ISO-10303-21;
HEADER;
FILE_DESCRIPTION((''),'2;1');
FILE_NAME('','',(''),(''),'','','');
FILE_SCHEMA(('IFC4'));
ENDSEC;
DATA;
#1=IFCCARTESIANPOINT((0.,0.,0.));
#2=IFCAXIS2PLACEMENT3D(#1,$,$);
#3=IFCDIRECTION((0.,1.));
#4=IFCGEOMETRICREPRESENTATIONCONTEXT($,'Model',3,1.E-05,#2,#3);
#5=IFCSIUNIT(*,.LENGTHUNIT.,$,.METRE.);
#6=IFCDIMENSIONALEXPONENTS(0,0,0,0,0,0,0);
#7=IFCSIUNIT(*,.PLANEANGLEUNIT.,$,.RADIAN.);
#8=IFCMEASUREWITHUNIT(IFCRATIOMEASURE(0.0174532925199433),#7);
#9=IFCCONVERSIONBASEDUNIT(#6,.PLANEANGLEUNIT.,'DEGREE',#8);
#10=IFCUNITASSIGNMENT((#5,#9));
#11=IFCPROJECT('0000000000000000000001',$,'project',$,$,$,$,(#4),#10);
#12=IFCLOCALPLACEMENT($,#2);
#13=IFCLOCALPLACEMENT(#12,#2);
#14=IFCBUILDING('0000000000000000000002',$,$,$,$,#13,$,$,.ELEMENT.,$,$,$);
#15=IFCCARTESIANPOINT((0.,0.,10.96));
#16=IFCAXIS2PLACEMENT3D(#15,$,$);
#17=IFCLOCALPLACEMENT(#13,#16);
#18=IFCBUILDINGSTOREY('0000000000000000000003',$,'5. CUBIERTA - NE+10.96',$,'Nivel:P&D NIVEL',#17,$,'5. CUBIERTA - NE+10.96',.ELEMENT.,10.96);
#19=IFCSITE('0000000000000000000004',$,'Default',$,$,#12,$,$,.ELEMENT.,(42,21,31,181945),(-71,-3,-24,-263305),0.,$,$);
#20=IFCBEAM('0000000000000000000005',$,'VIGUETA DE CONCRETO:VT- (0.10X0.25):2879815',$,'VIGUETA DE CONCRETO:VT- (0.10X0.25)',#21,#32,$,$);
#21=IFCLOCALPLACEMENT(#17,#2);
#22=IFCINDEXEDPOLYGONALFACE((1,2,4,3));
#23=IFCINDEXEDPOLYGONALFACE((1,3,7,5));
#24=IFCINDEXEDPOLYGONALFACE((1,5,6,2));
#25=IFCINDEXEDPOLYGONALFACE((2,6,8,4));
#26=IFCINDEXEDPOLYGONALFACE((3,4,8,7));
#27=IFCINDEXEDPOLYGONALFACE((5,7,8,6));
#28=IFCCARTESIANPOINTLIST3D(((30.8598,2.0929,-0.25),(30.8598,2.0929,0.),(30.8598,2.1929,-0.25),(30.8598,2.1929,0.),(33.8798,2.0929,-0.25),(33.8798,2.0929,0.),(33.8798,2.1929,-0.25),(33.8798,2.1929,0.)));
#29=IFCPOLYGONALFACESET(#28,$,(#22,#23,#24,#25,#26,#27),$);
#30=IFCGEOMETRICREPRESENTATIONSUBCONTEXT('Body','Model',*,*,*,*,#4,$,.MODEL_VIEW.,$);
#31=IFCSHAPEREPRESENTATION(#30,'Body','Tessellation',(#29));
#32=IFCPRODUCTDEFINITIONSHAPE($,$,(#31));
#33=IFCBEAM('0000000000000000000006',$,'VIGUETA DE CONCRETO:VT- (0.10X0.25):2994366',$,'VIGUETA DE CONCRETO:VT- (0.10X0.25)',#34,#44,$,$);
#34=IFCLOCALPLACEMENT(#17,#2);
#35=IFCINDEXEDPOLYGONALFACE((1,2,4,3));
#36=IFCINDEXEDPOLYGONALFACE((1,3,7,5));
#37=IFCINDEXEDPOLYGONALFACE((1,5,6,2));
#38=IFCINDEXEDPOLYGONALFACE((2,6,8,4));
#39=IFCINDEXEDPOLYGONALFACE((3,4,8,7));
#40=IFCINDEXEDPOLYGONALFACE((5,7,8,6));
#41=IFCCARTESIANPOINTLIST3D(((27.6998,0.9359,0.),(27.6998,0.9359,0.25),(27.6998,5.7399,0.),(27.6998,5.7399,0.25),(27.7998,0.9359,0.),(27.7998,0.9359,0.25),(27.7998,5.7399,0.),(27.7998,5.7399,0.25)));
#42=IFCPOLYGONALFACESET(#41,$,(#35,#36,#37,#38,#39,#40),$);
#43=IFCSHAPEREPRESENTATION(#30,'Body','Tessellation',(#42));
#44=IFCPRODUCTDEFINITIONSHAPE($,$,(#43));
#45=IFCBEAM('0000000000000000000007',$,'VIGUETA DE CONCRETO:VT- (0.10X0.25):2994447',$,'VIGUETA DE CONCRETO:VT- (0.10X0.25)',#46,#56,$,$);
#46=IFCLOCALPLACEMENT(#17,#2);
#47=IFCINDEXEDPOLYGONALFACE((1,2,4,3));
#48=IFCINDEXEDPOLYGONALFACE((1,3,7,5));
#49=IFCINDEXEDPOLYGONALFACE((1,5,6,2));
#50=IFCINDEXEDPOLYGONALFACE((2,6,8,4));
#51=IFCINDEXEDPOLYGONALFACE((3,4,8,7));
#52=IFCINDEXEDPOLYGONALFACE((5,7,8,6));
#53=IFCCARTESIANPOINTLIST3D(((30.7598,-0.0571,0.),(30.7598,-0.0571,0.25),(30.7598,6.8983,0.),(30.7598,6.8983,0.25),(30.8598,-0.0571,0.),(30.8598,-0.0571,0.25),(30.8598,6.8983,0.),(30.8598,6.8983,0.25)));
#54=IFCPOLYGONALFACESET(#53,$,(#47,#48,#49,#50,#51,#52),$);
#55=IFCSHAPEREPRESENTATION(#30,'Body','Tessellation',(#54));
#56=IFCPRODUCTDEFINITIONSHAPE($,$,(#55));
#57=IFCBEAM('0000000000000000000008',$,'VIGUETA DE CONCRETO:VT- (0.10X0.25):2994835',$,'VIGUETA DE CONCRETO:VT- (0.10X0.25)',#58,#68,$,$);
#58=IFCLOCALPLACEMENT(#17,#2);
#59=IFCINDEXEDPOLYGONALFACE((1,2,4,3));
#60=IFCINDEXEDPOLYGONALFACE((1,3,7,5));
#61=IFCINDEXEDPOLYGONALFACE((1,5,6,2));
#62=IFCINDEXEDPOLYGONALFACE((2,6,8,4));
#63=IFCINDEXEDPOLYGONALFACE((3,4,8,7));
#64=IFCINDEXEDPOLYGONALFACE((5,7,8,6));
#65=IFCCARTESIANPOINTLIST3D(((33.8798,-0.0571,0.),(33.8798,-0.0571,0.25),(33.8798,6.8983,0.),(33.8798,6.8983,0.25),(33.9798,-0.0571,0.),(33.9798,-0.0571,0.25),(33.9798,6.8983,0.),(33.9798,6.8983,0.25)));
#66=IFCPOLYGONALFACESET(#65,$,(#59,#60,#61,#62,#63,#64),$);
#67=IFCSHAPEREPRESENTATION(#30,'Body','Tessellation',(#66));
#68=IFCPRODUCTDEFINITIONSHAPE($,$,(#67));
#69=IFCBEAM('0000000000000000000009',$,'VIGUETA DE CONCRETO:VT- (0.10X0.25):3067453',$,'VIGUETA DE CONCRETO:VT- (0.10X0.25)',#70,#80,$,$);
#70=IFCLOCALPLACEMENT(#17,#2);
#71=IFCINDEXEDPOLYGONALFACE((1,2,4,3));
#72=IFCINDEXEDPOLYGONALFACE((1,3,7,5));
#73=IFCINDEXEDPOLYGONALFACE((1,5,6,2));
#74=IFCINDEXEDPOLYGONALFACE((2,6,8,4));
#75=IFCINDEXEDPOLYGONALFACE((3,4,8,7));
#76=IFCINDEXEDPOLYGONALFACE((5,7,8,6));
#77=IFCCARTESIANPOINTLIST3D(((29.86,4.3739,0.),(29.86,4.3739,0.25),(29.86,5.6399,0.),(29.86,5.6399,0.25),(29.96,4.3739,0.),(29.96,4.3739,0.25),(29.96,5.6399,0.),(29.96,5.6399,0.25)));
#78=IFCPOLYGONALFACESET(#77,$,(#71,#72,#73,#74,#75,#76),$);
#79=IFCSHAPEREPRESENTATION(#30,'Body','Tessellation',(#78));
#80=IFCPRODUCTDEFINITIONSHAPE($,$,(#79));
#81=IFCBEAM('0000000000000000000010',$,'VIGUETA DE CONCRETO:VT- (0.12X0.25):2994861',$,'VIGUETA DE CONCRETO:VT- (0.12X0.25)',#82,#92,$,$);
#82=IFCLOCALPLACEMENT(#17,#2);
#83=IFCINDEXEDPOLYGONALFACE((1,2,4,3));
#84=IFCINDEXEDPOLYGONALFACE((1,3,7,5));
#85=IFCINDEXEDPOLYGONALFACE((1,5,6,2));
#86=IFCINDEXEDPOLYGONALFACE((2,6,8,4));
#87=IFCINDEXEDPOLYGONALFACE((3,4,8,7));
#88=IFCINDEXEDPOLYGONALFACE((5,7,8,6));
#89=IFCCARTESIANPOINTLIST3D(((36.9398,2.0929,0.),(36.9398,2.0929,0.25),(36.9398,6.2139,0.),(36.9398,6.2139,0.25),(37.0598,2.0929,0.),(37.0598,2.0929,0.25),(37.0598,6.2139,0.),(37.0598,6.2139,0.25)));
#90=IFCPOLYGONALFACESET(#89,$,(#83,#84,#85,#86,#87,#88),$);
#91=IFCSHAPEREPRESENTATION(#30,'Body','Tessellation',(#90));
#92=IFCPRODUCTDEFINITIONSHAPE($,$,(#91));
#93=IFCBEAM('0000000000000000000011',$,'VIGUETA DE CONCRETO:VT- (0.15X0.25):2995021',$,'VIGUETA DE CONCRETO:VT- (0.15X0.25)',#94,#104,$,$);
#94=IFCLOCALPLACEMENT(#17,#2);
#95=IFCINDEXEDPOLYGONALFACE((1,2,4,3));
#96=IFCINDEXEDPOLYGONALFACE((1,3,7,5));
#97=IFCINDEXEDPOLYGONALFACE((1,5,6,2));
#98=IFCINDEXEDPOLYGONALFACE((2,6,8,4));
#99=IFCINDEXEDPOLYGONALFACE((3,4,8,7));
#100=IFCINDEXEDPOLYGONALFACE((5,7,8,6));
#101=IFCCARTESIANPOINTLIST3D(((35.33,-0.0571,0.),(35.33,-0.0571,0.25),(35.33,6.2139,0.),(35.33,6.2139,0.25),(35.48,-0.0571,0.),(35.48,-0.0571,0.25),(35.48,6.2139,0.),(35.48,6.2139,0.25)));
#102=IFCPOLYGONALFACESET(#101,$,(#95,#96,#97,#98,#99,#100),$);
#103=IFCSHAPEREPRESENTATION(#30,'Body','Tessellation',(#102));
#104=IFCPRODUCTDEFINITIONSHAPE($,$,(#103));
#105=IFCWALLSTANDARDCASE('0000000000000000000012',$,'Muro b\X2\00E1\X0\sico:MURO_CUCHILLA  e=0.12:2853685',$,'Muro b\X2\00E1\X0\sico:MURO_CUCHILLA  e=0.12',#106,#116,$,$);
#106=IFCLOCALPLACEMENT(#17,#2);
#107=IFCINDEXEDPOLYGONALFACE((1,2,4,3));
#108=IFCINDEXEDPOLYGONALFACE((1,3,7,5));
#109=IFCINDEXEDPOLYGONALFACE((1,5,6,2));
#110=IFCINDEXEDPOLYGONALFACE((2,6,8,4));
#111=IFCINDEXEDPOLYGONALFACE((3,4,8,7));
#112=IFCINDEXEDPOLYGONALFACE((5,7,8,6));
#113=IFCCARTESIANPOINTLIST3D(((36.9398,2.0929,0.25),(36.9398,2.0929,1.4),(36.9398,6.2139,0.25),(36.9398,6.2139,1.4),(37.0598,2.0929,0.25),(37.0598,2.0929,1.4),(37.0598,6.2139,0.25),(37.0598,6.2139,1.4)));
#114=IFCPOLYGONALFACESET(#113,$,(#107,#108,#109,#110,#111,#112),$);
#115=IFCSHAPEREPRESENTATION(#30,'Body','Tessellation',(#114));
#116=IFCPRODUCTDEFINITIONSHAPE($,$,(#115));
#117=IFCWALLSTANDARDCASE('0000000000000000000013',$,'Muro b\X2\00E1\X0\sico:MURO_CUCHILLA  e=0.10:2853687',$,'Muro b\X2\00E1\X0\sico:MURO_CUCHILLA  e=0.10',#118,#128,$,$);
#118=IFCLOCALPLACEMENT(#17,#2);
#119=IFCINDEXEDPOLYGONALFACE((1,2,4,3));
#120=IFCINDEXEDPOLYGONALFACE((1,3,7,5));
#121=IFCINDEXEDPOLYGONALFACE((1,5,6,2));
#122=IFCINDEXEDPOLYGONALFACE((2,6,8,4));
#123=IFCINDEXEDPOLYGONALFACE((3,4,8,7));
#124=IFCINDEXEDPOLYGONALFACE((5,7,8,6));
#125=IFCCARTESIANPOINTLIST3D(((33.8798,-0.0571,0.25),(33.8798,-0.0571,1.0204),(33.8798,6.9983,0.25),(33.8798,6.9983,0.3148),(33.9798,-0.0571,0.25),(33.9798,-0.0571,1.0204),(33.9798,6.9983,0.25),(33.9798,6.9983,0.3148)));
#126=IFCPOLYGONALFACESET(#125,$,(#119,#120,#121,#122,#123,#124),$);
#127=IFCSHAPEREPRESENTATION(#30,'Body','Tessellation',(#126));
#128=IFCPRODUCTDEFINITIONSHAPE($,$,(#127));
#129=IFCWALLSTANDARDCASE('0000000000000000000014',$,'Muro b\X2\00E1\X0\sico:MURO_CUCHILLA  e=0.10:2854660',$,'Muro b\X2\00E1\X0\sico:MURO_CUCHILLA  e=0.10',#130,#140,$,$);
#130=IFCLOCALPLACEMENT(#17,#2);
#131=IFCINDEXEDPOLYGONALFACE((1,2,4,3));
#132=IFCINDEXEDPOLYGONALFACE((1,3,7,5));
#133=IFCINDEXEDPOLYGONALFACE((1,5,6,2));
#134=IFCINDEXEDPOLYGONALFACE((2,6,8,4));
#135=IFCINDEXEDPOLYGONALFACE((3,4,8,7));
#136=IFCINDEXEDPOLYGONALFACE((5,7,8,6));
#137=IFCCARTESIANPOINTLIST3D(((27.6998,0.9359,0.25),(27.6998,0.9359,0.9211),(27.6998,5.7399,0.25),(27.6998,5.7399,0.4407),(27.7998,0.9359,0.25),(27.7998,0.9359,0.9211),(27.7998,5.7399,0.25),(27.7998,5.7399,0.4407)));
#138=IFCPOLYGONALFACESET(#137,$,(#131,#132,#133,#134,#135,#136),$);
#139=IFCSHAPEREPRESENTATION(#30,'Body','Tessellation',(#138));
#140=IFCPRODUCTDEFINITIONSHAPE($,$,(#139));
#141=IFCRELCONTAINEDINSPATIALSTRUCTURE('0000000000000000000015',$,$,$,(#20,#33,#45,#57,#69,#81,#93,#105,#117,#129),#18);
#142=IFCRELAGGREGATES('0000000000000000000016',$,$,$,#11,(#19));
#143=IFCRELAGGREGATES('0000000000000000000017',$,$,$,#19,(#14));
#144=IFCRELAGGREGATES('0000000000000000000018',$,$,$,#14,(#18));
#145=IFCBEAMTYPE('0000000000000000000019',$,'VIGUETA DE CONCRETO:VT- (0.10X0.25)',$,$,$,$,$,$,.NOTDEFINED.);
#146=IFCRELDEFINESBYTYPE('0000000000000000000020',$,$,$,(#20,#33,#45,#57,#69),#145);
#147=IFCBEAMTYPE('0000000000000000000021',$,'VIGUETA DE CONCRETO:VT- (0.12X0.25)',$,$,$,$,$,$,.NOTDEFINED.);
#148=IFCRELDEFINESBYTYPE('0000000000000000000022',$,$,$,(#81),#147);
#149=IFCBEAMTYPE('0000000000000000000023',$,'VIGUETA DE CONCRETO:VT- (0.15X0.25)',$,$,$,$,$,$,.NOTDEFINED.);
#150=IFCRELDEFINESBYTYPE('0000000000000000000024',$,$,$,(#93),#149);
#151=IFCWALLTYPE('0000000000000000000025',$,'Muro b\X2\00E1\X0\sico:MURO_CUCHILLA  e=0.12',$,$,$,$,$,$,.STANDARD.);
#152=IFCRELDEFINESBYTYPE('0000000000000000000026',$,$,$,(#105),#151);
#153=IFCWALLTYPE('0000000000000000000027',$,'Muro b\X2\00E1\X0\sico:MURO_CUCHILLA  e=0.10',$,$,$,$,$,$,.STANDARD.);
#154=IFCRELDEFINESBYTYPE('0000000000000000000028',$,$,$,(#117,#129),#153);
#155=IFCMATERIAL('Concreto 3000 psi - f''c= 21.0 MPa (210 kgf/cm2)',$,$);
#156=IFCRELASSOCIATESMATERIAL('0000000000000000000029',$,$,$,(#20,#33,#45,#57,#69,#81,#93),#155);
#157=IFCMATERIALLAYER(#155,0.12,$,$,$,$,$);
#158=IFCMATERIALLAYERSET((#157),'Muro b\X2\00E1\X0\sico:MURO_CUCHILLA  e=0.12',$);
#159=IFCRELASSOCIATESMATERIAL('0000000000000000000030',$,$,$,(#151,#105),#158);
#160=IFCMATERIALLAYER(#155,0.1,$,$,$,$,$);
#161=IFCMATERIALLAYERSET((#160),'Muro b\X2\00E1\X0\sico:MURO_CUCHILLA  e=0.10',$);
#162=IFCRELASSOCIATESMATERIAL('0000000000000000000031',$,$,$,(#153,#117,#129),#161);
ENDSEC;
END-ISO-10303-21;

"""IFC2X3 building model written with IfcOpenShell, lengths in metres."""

from ifc_helpers import new_model, entity, si_unit, converted_unit, direction, frame, frame_2d, origin, place, context, subcontext, project, spatial, rectangle, extrude, clip, halfspace, material, layer, layer_set, layer_usage, type_object, element, save


model = new_model("IFC2X3")

# Units and contexts
model_context = context("Model", 3, precision=1e-05, world=origin(), true_north=direction((0.0, 1.0)))
body_context = subcontext(model_context, "Body", "Model", "MODEL_VIEW")
ifc_project = project(units=[si_unit("LENGTHUNIT", "METRE"), converted_unit("PLANEANGLEUNIT", "DEGREE", entity("IfcRatioMeasure", 0.0174532925199433), si_unit("PLANEANGLEUNIT", "RADIAN"), dimensions=[0, 0, 0, 0, 0, 0, 0])], contexts=[model_context])

# Site, building, storey
site_placement = place(None, origin())
site = spatial("IfcSite", under=ifc_project, at=site_placement, Name="Default", CompositionType="ELEMENT", RefLatitude=(42, 21, 31, 181945), RefLongitude=(-71, -3, -24, -263305), RefElevation=0.0)
building_placement = place(site_placement, origin())
building = spatial("IfcBuilding", under=site, at=building_placement, CompositionType="ELEMENT")
storey_placement = place(building_placement, frame((0.0, 0.0, 10.96)))
storey = spatial("IfcBuildingStorey", under=building, at=storey_placement, Name="5. CUBIERTA - NE+10.96", ObjectType="Nivel:P&D NIVEL", LongName="5. CUBIERTA - NE+10.96", CompositionType="ELEMENT", Elevation=10.96)

# Beams
ifc_material_1 = material(Name="Concreto 3000 psi - f'c= 21.0 MPa (210 kgf/cm2)")
beam_type_1 = type_object("IfcBeamType", Name="VIGUETA DE CONCRETO:VT- (0.10X0.25)", PredefinedType="NOTDEFINED")
beam_1_placement = place(storey_placement, frame((30.8098, 2.1429, 0.0)))
element("IfcBeam", 1, at=beam_1_placement, inside=storey, type_object=beam_type_1, material=ifc_material_1, Name="VIGUETA DE CONCRETO:VT- (0.10X0.25):2879815", ObjectType="VIGUETA DE CONCRETO:VT- (0.10X0.25)", context=body_context, shape_type="SweptSolid", body=[
    extrude(rectangle(XDim=0.25, YDim=0.1, at=frame_2d((0.0, 0.0), x_axis=(1.0, 0.0))), frame((0.05, 0.0, -0.125), z_axis=(1.0, 0.0, 0.0), x_axis=(0.0, 0.0, -1.0)), (0.0, 0.0, 1.0), 3.02),
])
beam_2_placement = place(storey_placement, frame((27.7498, 5.7399, 0.0), z_axis=(0.0, 0.0, 1.0), x_axis=(0.0, -1.0, 0.0)))
element("IfcBeam", 2, at=beam_2_placement, inside=storey, type_object=beam_type_1, material=ifc_material_1, Name="VIGUETA DE CONCRETO:VT- (0.10X0.25):2994366", ObjectType="VIGUETA DE CONCRETO:VT- (0.10X0.25)", context=body_context, shape_type="SweptSolid", body=[
    extrude(rectangle(XDim=0.25, YDim=0.1, at=frame_2d((0.0, 0.0), x_axis=(1.0, 0.0))), frame((0.0, 0.0, 0.125), z_axis=(1.0, 0.0, 0.0), x_axis=(0.0, 0.0, -1.0)), (0.0, 0.0, 1.0), 4.804),
])
beam_3_placement = place(storey_placement, frame((30.8098, 6.9983, 0.0), z_axis=(0.0, 0.0, 1.0), x_axis=(0.0, -1.0, 0.0)))
element("IfcBeam", 3, at=beam_3_placement, inside=storey, type_object=beam_type_1, material=ifc_material_1, Name="VIGUETA DE CONCRETO:VT- (0.10X0.25):2994447", ObjectType="VIGUETA DE CONCRETO:VT- (0.10X0.25)", context=body_context, shape_type="SweptSolid", body=[
    extrude(rectangle(XDim=0.25, YDim=0.1, at=frame_2d((0.0, 0.0), x_axis=(1.0, 0.0))), frame((0.1, 0.0, 0.125), z_axis=(1.0, 0.0, 0.0), x_axis=(0.0, 0.0, -1.0)), (0.0, 0.0, 1.0), 6.9554),
])
beam_4_placement = place(storey_placement, frame((33.9298, 6.9983, 0.0), z_axis=(0.0, 0.0, 1.0), x_axis=(0.0, -1.0, 0.0)))
element("IfcBeam", 4, at=beam_4_placement, inside=storey, type_object=beam_type_1, material=ifc_material_1, Name="VIGUETA DE CONCRETO:VT- (0.10X0.25):2994835", ObjectType="VIGUETA DE CONCRETO:VT- (0.10X0.25)", context=body_context, shape_type="SweptSolid", body=[
    extrude(rectangle(XDim=0.25, YDim=0.1, at=frame_2d((0.0, 0.0), x_axis=(1.0, 0.0))), frame((0.1, 0.0, 0.125), z_axis=(1.0, 0.0, 0.0), x_axis=(0.0, 0.0, -1.0)), (0.0, 0.0, 1.0), 6.9554),
])
beam_5_placement = place(storey_placement, frame((29.91, 4.3239, 0.0), z_axis=(0.0, 0.0, 1.0), x_axis=(0.0, 1.0, 0.0)))
element("IfcBeam", 5, at=beam_5_placement, inside=storey, type_object=beam_type_1, material=ifc_material_1, Name="VIGUETA DE CONCRETO:VT- (0.10X0.25):3067453", ObjectType="VIGUETA DE CONCRETO:VT- (0.10X0.25)", context=body_context, shape_type="SweptSolid", body=[
    extrude(rectangle(XDim=0.25, YDim=0.1, at=frame_2d((0.0, 0.0), x_axis=(1.0, 0.0))), frame((0.05, 0.0, 0.125), z_axis=(1.0, 0.0, 0.0), x_axis=(0.0, 0.0, -1.0)), (0.0, 0.0, 1.0), 1.266),
])
beam_type_2 = type_object("IfcBeamType", Name="VIGUETA DE CONCRETO:VT- (0.12X0.25)", PredefinedType="NOTDEFINED")
beam_6_placement = place(storey_placement, frame((36.9998, 6.2139, 0.0), z_axis=(0.0, 0.0, 1.0), x_axis=(0.0, -1.0, 0.0)))
element("IfcBeam", 6, at=beam_6_placement, inside=storey, type_object=beam_type_2, material=ifc_material_1, Name="VIGUETA DE CONCRETO:VT- (0.12X0.25):2994861", ObjectType="VIGUETA DE CONCRETO:VT- (0.12X0.25)", context=body_context, shape_type="SweptSolid", body=[
    extrude(rectangle(XDim=0.25, YDim=0.12, at=frame_2d((0.0, 0.0), x_axis=(1.0, 0.0))), frame((0.0, 0.0, 0.125), z_axis=(1.0, 0.0, 0.0), x_axis=(0.0, 0.0, -1.0)), (0.0, 0.0, 1.0), 4.121),
])
beam_type_3 = type_object("IfcBeamType", Name="VIGUETA DE CONCRETO:VT- (0.15X0.25)", PredefinedType="NOTDEFINED")
beam_7_placement = place(storey_placement, frame((35.405, 6.2139, 0.0), z_axis=(0.0, 0.0, 1.0), x_axis=(0.0, -1.0, 0.0)))
element("IfcBeam", 7, at=beam_7_placement, inside=storey, type_object=beam_type_3, material=ifc_material_1, Name="VIGUETA DE CONCRETO:VT- (0.15X0.25):2995021", ObjectType="VIGUETA DE CONCRETO:VT- (0.15X0.25)", context=body_context, shape_type="SweptSolid", body=[
    extrude(rectangle(XDim=0.25, YDim=0.15, at=frame_2d((0.0, 0.0), x_axis=(1.0, 0.0))), frame((0.0, 0.0, 0.125), z_axis=(1.0, 0.0, 0.0), x_axis=(0.0, 0.0, -1.0)), (0.0, 0.0, 1.0), 6.271),
])

# Walls
ifc_layer_1 = layer(ifc_material_1, 0.12)
ifc_layer_set_1 = layer_set([ifc_layer_1], Name="Muro básico:MURO_CUCHILLA  e=0.12")
ifc_layer_usage_1 = layer_usage(ifc_layer_set_1, "AXIS2", "POSITIVE", -0.06)
wall_type_1 = type_object("IfcWallType", Name="Muro básico:MURO_CUCHILLA  e=0.12", PredefinedType="STANDARD", material=ifc_layer_set_1)
wall_1_placement = place(storey_placement, frame((36.9998, 6.2139, 0.25), z_axis=(0.0, 0.0, 1.0), x_axis=(0.0, -1.0, 0.0)))
element("IfcWallStandardCase", 8, at=wall_1_placement, inside=storey, type_object=wall_type_1, material=ifc_layer_usage_1, Name="Muro básico:MURO_CUCHILLA  e=0.12:2853685", ObjectType="Muro básico:MURO_CUCHILLA  e=0.12", context=body_context, shape_type="SweptSolid", body=[
    extrude(rectangle(XDim=4.121, YDim=0.12, at=frame_2d((2.0605, 0.0), x_axis=(-1.0, 0.0))), origin(), (0.0, 0.0, 1.0), 1.15),
])
ifc_layer_2 = layer(ifc_material_1, 0.1)
ifc_layer_set_2 = layer_set([ifc_layer_2], Name="Muro básico:MURO_CUCHILLA  e=0.10")
ifc_layer_usage_2 = layer_usage(ifc_layer_set_2, "AXIS2", "POSITIVE", -0.05)
wall_type_2 = type_object("IfcWallType", Name="Muro básico:MURO_CUCHILLA  e=0.10", PredefinedType="STANDARD", material=ifc_layer_set_2)
wall_2_placement = place(storey_placement, frame((33.9298, 6.9983, 0.25), z_axis=(0.0, 0.0, 1.0), x_axis=(0.0, -1.0, 0.0)))
element("IfcWallStandardCase", 9, at=wall_2_placement, inside=storey, type_object=wall_type_2, material=ifc_layer_usage_2, Name="Muro básico:MURO_CUCHILLA  e=0.10:2853687", ObjectType="Muro básico:MURO_CUCHILLA  e=0.10", context=body_context, shape_type="Clipping", body=[
    clip(extrude(rectangle(XDim=7.0554, YDim=0.1, at=frame_2d((3.5277, 0.0), x_axis=(-1.0, 0.0))), origin(), (0.0, 0.0, 1.0), 0.7704), halfspace(frame((0.0, -0.05, 0.0648), z_axis=(-0.099504, 0.0, 0.995037), x_axis=(0.0, 1.0, 0.0)), False)),
])

# Wall
wall_3_placement = place(storey_placement, frame((27.7498, 5.7399, 0.25), z_axis=(0.0, 0.0, 1.0), x_axis=(0.0, -1.0, 0.0)))
element("IfcWallStandardCase", 10, at=wall_3_placement, inside=storey, type_object=wall_type_2, material=ifc_layer_usage_2, Name="Muro básico:MURO_CUCHILLA  e=0.10:2854660", ObjectType="Muro básico:MURO_CUCHILLA  e=0.10", context=body_context, shape_type="Clipping", body=[
    clip(extrude(rectangle(XDim=4.804, YDim=0.1, at=frame_2d((2.402, 0.0), x_axis=(-1.0, 0.0))), origin(), (0.0, 0.0, 1.0), 0.6711), halfspace(frame((0.0, -0.05, 0.1907), z_axis=(-0.099504, 0.0, 0.995037), x_axis=(0.0, 1.0, 0.0)), False)),
])

save(model, "model.ifc")
